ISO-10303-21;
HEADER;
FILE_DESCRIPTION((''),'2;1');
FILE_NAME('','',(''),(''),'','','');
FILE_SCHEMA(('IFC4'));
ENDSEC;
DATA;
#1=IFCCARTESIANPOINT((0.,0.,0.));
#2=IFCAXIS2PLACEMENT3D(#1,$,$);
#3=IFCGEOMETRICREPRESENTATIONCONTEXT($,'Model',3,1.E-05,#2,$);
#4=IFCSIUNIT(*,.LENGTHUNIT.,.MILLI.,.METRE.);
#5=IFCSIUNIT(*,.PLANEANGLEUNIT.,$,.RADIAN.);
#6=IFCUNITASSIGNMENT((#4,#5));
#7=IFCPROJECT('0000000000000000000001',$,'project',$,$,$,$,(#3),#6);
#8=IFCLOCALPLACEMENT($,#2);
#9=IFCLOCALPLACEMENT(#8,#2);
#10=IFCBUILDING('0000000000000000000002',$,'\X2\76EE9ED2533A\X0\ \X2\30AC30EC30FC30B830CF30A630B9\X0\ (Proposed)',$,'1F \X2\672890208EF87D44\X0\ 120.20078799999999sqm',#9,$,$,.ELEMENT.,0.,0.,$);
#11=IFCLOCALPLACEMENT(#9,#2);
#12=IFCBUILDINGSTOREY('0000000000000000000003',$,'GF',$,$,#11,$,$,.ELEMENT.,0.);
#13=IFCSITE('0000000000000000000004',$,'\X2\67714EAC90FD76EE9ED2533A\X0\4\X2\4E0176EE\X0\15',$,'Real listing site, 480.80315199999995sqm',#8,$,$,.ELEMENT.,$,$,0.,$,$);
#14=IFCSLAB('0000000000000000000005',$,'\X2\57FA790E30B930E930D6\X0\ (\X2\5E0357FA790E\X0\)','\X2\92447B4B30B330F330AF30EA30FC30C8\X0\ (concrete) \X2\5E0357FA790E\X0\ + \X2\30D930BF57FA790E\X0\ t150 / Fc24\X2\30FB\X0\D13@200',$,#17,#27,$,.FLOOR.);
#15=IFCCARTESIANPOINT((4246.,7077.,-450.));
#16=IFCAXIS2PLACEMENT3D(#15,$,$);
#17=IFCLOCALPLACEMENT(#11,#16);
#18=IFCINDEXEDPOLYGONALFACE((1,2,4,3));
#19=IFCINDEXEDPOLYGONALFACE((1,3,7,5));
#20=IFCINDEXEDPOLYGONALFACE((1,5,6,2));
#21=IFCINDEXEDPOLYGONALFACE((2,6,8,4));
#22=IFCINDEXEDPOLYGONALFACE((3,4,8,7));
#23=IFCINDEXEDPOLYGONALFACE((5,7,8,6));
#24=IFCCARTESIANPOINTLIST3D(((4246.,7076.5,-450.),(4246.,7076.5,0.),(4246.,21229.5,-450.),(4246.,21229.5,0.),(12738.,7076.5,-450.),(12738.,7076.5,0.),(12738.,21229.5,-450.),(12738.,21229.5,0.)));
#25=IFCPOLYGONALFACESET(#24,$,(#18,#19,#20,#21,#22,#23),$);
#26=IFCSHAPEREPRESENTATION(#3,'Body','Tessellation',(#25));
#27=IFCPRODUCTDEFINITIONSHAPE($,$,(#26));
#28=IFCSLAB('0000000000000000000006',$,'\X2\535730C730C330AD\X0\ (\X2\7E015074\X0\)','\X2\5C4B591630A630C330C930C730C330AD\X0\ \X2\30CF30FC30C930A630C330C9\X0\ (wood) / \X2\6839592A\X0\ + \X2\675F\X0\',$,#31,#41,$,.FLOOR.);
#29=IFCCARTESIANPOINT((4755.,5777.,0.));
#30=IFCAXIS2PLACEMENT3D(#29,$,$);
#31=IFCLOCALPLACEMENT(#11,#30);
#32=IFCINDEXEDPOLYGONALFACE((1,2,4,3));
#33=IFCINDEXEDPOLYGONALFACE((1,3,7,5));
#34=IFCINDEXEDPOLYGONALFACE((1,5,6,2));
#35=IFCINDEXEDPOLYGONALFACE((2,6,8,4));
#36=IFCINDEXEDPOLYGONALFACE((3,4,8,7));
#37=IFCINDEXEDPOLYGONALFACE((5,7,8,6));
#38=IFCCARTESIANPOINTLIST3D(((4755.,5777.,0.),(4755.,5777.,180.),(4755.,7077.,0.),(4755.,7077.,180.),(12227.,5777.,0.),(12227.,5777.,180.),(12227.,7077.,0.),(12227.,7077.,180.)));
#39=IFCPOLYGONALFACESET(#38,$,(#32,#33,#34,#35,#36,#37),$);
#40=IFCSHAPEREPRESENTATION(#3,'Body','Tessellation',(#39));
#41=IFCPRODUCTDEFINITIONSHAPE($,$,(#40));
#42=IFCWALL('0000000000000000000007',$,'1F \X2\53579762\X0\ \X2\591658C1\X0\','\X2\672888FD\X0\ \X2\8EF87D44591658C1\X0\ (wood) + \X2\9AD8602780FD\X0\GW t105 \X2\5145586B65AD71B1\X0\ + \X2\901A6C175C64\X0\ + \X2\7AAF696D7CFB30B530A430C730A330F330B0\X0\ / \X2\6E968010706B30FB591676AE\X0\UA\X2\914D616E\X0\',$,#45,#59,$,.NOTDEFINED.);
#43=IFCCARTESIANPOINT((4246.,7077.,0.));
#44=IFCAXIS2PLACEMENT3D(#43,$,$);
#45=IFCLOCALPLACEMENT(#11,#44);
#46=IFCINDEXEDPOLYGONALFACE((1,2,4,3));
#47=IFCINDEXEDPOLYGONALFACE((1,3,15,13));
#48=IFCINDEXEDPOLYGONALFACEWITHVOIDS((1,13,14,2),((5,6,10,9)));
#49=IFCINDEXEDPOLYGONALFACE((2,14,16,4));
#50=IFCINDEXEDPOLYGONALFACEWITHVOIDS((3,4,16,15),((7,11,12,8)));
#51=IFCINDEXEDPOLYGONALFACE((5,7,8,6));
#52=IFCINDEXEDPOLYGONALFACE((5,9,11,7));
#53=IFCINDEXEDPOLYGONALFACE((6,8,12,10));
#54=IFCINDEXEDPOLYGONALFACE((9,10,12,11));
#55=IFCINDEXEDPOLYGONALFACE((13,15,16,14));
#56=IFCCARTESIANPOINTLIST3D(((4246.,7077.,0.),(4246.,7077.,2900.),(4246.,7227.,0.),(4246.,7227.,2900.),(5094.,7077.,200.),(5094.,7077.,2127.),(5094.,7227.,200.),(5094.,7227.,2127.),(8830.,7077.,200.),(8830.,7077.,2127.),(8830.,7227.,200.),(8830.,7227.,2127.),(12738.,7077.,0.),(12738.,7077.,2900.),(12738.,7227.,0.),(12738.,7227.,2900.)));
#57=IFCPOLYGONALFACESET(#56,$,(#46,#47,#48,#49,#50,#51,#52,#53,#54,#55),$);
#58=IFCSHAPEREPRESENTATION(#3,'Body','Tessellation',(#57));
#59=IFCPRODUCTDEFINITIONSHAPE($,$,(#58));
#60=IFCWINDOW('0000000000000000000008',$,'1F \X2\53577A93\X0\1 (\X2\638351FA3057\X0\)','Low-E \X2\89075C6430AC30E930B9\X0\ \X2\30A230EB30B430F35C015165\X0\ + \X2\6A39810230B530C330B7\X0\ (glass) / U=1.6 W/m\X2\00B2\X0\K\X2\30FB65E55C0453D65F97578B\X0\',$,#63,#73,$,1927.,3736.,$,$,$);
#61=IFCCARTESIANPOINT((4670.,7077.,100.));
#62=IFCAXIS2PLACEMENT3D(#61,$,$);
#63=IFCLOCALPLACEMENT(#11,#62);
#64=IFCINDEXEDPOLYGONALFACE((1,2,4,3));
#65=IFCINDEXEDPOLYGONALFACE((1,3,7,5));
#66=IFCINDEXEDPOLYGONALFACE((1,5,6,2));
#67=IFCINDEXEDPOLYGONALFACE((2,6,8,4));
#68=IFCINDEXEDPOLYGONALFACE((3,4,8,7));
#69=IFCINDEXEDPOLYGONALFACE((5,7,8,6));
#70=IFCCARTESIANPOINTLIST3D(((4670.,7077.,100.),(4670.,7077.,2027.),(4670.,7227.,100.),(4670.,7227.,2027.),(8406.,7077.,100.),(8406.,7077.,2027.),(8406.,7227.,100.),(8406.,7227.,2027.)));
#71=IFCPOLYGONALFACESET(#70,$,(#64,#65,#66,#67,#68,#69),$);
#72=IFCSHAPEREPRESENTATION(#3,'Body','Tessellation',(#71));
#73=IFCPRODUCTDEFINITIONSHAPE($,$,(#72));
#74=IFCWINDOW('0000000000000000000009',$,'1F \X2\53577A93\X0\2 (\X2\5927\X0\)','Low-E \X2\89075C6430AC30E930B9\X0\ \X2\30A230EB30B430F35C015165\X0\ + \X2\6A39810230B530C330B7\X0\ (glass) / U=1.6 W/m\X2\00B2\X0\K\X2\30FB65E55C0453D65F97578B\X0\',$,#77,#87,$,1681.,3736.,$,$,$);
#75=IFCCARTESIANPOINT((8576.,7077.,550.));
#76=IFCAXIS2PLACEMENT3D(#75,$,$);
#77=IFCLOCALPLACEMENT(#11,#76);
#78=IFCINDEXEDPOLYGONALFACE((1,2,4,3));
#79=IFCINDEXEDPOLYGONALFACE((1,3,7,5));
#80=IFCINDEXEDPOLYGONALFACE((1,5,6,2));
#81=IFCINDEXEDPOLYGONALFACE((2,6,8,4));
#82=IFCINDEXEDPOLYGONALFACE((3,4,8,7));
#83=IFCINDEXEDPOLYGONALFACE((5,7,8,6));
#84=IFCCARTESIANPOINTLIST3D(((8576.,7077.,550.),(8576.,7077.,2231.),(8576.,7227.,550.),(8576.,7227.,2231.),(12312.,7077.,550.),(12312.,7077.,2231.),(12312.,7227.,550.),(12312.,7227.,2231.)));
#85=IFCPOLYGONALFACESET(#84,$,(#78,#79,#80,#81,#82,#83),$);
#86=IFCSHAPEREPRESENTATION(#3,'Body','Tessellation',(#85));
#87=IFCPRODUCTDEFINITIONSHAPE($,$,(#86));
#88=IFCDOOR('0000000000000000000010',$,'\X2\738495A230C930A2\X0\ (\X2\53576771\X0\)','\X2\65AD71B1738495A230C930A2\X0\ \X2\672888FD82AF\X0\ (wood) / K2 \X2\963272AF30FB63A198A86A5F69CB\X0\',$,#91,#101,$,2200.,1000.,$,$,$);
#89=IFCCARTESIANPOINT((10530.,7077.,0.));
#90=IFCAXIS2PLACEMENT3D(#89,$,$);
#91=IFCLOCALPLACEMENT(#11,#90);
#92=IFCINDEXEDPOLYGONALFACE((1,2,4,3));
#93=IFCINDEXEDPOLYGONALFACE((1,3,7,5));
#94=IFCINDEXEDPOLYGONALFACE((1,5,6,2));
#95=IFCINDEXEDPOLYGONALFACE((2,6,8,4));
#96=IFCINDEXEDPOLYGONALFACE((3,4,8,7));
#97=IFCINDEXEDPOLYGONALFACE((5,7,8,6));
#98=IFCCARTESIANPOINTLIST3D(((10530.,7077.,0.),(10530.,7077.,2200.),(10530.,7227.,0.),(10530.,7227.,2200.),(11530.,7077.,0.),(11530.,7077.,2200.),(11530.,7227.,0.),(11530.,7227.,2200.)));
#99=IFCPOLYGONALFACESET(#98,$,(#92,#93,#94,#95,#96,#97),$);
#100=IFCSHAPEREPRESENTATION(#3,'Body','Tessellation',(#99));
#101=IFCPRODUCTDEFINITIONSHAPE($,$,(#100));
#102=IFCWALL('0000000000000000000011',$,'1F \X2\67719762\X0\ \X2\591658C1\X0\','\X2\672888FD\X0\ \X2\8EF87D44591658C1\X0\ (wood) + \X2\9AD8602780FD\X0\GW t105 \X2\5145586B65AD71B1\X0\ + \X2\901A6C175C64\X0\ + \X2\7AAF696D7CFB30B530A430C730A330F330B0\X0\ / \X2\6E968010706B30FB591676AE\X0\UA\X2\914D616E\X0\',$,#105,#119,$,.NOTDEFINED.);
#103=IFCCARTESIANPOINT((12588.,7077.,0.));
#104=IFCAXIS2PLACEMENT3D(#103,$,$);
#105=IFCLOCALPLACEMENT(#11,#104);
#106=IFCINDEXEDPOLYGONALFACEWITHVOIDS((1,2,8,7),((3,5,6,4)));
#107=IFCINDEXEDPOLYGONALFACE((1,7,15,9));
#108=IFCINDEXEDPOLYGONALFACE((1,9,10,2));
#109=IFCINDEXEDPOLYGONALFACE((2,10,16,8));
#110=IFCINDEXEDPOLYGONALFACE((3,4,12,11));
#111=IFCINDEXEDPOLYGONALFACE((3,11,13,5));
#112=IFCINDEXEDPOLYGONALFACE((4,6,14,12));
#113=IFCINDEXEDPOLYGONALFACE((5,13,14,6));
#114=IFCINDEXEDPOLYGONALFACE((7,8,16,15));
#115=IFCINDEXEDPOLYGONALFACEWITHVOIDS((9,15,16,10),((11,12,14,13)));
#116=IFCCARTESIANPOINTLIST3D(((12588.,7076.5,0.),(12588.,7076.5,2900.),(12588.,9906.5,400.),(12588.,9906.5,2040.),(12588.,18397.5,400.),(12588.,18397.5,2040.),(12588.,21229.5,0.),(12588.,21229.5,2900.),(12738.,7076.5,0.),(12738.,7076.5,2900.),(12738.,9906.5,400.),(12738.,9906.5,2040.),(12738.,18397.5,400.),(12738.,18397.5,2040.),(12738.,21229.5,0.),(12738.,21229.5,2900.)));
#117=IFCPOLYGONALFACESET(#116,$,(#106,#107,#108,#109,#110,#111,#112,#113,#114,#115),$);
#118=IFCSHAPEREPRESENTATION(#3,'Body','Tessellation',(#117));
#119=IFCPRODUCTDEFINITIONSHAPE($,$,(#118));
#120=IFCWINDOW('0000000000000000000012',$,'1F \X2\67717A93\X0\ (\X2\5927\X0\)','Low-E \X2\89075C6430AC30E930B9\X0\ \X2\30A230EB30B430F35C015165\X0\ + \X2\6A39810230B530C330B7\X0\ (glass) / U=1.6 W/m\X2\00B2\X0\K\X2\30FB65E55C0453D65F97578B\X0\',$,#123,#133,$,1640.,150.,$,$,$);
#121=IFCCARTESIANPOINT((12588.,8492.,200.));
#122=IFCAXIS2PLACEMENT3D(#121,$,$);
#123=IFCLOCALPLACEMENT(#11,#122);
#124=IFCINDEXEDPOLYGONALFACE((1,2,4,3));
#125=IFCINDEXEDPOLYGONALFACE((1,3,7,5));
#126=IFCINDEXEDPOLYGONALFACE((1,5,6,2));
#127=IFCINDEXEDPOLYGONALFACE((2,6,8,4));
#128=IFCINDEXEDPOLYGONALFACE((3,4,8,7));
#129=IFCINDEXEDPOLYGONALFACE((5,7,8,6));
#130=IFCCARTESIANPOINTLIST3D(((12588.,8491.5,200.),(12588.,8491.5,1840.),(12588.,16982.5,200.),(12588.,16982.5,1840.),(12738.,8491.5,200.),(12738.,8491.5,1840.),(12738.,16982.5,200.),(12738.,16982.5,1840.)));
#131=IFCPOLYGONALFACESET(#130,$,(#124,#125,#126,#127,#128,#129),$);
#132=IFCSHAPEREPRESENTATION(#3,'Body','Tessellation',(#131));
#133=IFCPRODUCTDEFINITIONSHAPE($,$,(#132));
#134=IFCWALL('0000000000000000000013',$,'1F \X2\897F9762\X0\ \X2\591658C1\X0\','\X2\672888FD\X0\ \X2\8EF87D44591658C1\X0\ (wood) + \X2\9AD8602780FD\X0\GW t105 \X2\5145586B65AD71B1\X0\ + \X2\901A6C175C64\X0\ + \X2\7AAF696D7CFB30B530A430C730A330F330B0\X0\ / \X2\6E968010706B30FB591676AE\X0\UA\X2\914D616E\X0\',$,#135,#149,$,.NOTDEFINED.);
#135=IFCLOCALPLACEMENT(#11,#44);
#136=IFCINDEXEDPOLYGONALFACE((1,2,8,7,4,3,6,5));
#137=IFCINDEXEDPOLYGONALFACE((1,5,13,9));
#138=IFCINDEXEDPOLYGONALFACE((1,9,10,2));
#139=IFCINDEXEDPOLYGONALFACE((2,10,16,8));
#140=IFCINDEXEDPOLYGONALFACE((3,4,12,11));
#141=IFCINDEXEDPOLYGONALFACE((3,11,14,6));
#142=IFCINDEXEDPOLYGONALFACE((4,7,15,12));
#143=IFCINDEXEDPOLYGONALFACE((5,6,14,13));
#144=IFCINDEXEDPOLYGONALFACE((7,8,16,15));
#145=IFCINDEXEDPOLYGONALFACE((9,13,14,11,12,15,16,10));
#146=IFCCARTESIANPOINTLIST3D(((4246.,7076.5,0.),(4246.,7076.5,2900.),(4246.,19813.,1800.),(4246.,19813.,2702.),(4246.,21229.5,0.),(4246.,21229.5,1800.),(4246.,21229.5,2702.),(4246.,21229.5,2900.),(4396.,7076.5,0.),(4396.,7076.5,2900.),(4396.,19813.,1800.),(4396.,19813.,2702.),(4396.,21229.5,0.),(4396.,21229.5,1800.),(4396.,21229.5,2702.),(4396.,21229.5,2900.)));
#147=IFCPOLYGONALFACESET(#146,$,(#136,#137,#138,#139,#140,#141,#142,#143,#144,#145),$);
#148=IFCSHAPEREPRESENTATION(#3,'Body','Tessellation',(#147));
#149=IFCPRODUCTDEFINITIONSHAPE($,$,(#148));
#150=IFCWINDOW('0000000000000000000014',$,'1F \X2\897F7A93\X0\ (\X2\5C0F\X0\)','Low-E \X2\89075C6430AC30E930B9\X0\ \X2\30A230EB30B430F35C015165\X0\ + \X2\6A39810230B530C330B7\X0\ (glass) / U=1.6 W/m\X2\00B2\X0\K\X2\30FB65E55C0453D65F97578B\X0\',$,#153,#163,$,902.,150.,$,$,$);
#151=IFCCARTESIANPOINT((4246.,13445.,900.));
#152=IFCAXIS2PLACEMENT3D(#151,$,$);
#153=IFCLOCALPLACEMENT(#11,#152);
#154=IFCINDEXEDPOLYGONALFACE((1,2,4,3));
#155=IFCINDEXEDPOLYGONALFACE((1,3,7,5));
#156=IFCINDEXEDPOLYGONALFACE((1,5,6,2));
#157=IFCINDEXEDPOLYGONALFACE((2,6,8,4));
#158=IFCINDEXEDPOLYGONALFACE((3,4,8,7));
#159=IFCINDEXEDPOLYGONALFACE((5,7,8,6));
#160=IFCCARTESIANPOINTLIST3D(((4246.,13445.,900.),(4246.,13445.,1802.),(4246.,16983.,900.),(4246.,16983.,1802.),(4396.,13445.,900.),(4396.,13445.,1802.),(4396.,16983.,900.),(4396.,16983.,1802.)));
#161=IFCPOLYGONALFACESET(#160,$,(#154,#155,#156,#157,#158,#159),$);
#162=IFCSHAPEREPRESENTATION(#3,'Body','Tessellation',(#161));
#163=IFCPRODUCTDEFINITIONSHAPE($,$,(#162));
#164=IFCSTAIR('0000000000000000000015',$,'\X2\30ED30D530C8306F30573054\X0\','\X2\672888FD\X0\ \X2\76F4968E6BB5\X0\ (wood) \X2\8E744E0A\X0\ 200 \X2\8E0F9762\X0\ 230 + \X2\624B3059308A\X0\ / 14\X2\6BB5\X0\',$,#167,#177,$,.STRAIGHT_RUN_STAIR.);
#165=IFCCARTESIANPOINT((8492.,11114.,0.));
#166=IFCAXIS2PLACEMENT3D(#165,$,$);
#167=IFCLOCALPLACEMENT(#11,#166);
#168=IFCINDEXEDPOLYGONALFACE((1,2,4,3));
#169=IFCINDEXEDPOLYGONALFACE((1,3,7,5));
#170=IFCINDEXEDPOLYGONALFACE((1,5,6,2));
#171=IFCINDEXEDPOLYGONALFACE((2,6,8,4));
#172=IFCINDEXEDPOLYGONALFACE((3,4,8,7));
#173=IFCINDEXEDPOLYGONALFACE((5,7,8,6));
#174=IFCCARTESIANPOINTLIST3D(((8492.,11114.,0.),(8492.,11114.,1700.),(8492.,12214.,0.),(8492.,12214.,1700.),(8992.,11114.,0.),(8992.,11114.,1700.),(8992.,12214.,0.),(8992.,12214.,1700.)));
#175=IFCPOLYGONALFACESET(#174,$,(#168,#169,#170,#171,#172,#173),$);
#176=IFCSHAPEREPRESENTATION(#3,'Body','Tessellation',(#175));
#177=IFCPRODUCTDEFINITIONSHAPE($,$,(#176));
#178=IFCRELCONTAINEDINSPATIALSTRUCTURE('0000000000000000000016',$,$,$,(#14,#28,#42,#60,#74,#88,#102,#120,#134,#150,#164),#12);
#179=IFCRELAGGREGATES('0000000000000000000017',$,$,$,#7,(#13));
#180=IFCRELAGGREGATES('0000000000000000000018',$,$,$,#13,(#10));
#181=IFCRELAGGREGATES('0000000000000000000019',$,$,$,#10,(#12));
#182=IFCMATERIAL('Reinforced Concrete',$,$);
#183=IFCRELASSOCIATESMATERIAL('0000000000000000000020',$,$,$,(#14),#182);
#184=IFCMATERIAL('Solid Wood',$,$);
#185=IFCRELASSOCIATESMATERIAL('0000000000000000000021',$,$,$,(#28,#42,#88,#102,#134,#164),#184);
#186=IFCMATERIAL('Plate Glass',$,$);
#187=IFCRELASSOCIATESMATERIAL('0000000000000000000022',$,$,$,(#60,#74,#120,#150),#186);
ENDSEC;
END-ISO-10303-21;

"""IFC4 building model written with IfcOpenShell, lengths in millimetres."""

from ifc_helpers import new_model, si_unit, frame, frame_2d, origin, place, context, project, spatial, rectangle, extrude, material, element, fill, save


model = new_model("IFC4")

# Units and contexts
model_context = context("Model", 3, precision=1e-05, world=origin())
ifc_project = project(units=[si_unit("LENGTHUNIT", "METRE", prefix="MILLI"), si_unit("PLANEANGLEUNIT", "RADIAN")], contexts=[model_context])

# Site, building, storey
site_placement = place(None, origin())
site = spatial("IfcSite", under=ifc_project, at=site_placement, Name="東京都目黒区4丁目15", ObjectType="Real listing site, 480.80315199999995sqm", CompositionType="ELEMENT", RefElevation=0.0)
building_placement = place(site_placement, origin())
building = spatial("IfcBuilding", under=site, at=building_placement, Name="目黒区 ガレージハウス (Proposed)", ObjectType="1F 木造軸組 120.20078799999999sqm", CompositionType="ELEMENT", ElevationOfRefHeight=0.0, ElevationOfTerrain=0.0)
storey_placement = place(building_placement, origin())
storey = spatial("IfcBuildingStorey", under=building, at=storey_placement, Name="GF", CompositionType="ELEMENT", Elevation=0.0)

# Slabs
ifc_material_1 = material(Name="Reinforced Concrete")
slab_1_placement = place(storey_placement, frame((4246.0, 7077.0, -450.0)))
element("IfcSlab", 1, at=slab_1_placement, inside=storey, material=ifc_material_1, Name="基礎スラブ (布基礎)", Description="鉄筋コンクリート (concrete) 布基礎 + ベタ基礎 t150 / Fc24・D13@200", PredefinedType="FLOOR", context=model_context, shape_type="SweptSolid", body=[
    extrude(rectangle(XDim=8492.0, YDim=14153.0, at=frame_2d((4246.0, 7076.0))), frame((4246.0, 7077.0, -450.0)), (0.0, 0.0, 1.0), 450.0),
])
ifc_material_2 = material(Name="Solid Wood")
slab_2_placement = place(storey_placement, frame((4755.0, 5777.0, 0.0)))
element("IfcSlab", 2, at=slab_2_placement, inside=storey, material=ifc_material_2, Name="南デッキ (縁側)", Description="屋外ウッドデッキ ハードウッド (wood) / 根太 + 束", PredefinedType="FLOOR", context=model_context, shape_type="SweptSolid", body=[
    extrude(rectangle(XDim=7472.0, YDim=1300.0, at=frame_2d((3736.0, 650.0))), frame((4755.0, 5777.0, 0.0)), (0.0, 0.0, 1.0), 180.0),
])

# Wall, openings, windows, door
wall_1_placement = place(storey_placement, frame((4246.0, 7077.0, 0.0)))
wall_1 = element("IfcWall", 3, at=wall_1_placement, inside=storey, material=ifc_material_2, Name="1F 南面 外壁", Description="木製 軸組外壁 (wood) + 高性能GW t105 充填断熱 + 通気層 + 窯業系サイディング / 準耐火・外皮UA配慮", PredefinedType="NOTDEFINED", context=model_context, shape_type="SweptSolid", body=[
    extrude(rectangle(XDim=8492.0, YDim=150.0, at=frame_2d((4246.0, 75.0))), frame((4246.0, 7077.0, 0.0)), (0.0, 0.0, 1.0), 2900.0),
])
opening_1_placement = place(storey_placement, frame((4670.0, 7077.0, 100.0)))
opening_1 = element("IfcOpeningElement", 4, at=opening_1_placement, cuts=wall_1, PredefinedType="NOTDEFINED", context=model_context, shape_type="SweptSolid", body=[
    extrude(rectangle(XDim=3736.0, YDim=150.0, at=frame_2d((1868.0, 75.0))), frame((4670.0, 7077.0, 100.0)), (0.0, 0.0, 1.0), 1927.0),
])
opening_2_placement = place(storey_placement, frame((8576.0, 7077.0, 550.0)))
opening_2 = element("IfcOpeningElement", 5, at=opening_2_placement, cuts=wall_1, PredefinedType="NOTDEFINED", context=model_context, shape_type="SweptSolid", body=[
    extrude(rectangle(XDim=3736.0, YDim=150.0, at=frame_2d((1868.0, 75.0))), frame((8576.0, 7077.0, 550.0)), (0.0, 0.0, 1.0), 1681.0),
])
opening_3_placement = place(storey_placement, frame((10530.0, 7077.0, 0.0)))
opening_3 = element("IfcOpeningElement", 6, at=opening_3_placement, cuts=wall_1, PredefinedType="NOTDEFINED", context=model_context, shape_type="SweptSolid", body=[
    extrude(rectangle(XDim=1000.0, YDim=150.0, at=frame_2d((500.0, 75.0))), frame((10530.0, 7077.0, 0.0)), (0.0, 0.0, 1.0), 2200.0),
])
ifc_material_3 = material(Name="Plate Glass")
window_1_placement = place(storey_placement, frame((4670.0, 7077.0, 100.0)))
window_1 = element("IfcWindow", 7, at=window_1_placement, inside=storey, material=ifc_material_3, Name="1F 南窓1 (掃出し)", Description="Low-E 複層ガラス アルゴン封入 + 樹脂サッシ (glass) / U=1.6 W/m²K・日射取得型", OverallHeight=1927.0, OverallWidth=3736.0, context=model_context, shape_type="SweptSolid", body=[
    extrude(rectangle(XDim=3736.0, YDim=150.0, at=frame_2d((1868.0, 75.0))), frame((4670.0, 7077.0, 100.0)), (0.0, 0.0, 1.0), 1927.0),
])
fill(opening_1, window_1)
window_2_placement = place(storey_placement, frame((8576.0, 7077.0, 550.0)))
window_2 = element("IfcWindow", 8, at=window_2_placement, inside=storey, material=ifc_material_3, Name="1F 南窓2 (大)", Description="Low-E 複層ガラス アルゴン封入 + 樹脂サッシ (glass) / U=1.6 W/m²K・日射取得型", OverallHeight=1681.0, OverallWidth=3736.0, context=model_context, shape_type="SweptSolid", body=[
    extrude(rectangle(XDim=3736.0, YDim=150.0, at=frame_2d((1868.0, 75.0))), frame((8576.0, 7077.0, 550.0)), (0.0, 0.0, 1.0), 1681.0),
])
fill(opening_2, window_2)
door_placement = place(storey_placement, frame((10530.0, 7077.0, 0.0)))
door = element("IfcDoor", 9, at=door_placement, inside=storey, material=ifc_material_2, Name="玄関ドア (南東)", Description="断熱玄関ドア 木製芯 (wood) / K2 防犯・採風機構", OverallHeight=2200.0, OverallWidth=1000.0, context=model_context, shape_type="SweptSolid", body=[
    extrude(rectangle(XDim=1000.0, YDim=150.0, at=frame_2d((500.0, 75.0))), frame((10530.0, 7077.0, 0.0)), (0.0, 0.0, 1.0), 2200.0),
])
fill(opening_3, door)

# Walls, openings, windows
wall_2_placement = place(storey_placement, frame((12588.0, 7077.0, 0.0)))
wall_2 = element("IfcWall", 10, at=wall_2_placement, inside=storey, material=ifc_material_2, Name="1F 東面 外壁", Description="木製 軸組外壁 (wood) + 高性能GW t105 充填断熱 + 通気層 + 窯業系サイディング / 準耐火・外皮UA配慮", PredefinedType="NOTDEFINED", context=model_context, shape_type="SweptSolid", body=[
    extrude(rectangle(XDim=150.0, YDim=14153.0, at=frame_2d((75.0, 7076.0))), frame((12588.0, 7077.0, 0.0)), (0.0, 0.0, 1.0), 2900.0),
])
opening_4_placement = place(storey_placement, frame((12588.0, 8492.0, 200.0)))
opening_4 = element("IfcOpeningElement", 11, at=opening_4_placement, cuts=wall_2, PredefinedType="NOTDEFINED", context=model_context, shape_type="SweptSolid", body=[
    extrude(rectangle(XDim=150.0, YDim=8491.0, at=frame_2d((75.0, 4245.0))), frame((12588.0, 8492.0, 200.0)), (0.0, 0.0, 1.0), 1640.0),
])
window_3_placement = place(storey_placement, frame((12588.0, 8492.0, 200.0)))
window_3 = element("IfcWindow", 12, at=window_3_placement, inside=storey, material=ifc_material_3, Name="1F 東窓 (大)", Description="Low-E 複層ガラス アルゴン封入 + 樹脂サッシ (glass) / U=1.6 W/m²K・日射取得型", OverallHeight=1640.0, OverallWidth=150.0, context=model_context, shape_type="SweptSolid", body=[
    extrude(rectangle(XDim=150.0, YDim=8491.0, at=frame_2d((75.0, 4245.0))), frame((12588.0, 8492.0, 200.0)), (0.0, 0.0, 1.0), 1640.0),
])
fill(opening_4, window_3)
wall_3_placement = place(storey_placement, frame((4246.0, 7077.0, 0.0)))
wall_3 = element("IfcWall", 13, at=wall_3_placement, inside=storey, material=ifc_material_2, Name="1F 西面 外壁", Description="木製 軸組外壁 (wood) + 高性能GW t105 充填断熱 + 通気層 + 窯業系サイディング / 準耐火・外皮UA配慮", PredefinedType="NOTDEFINED", context=model_context, shape_type="SweptSolid", body=[
    extrude(rectangle(XDim=150.0, YDim=14153.0, at=frame_2d((75.0, 7076.0))), frame((4246.0, 7077.0, 0.0)), (0.0, 0.0, 1.0), 2900.0),
])
opening_5_placement = place(storey_placement, frame((4246.0, 13445.0, 900.0)))
opening_5 = element("IfcOpeningElement", 14, at=opening_5_placement, cuts=wall_3, PredefinedType="NOTDEFINED", context=model_context, shape_type="SweptSolid", body=[
    extrude(rectangle(XDim=150.0, YDim=3538.0, at=frame_2d((75.0, 1769.0))), frame((4246.0, 13445.0, 900.0)), (0.0, 0.0, 1.0), 902.0),
])
window_4_placement = place(storey_placement, frame((4246.0, 13445.0, 900.0)))
window_4 = element("IfcWindow", 15, at=window_4_placement, inside=storey, material=ifc_material_3, Name="1F 西窓 (小)", Description="Low-E 複層ガラス アルゴン封入 + 樹脂サッシ (glass) / U=1.6 W/m²K・日射取得型", OverallHeight=902.0, OverallWidth=150.0, context=model_context, shape_type="SweptSolid", body=[
    extrude(rectangle(XDim=150.0, YDim=3538.0, at=frame_2d((75.0, 1769.0))), frame((4246.0, 13445.0, 900.0)), (0.0, 0.0, 1.0), 902.0),
])
fill(opening_5, window_4)

# Stair
stair_placement = place(storey_placement, frame((8492.0, 11114.0, 0.0)))
element("IfcStair", 16, at=stair_placement, inside=storey, material=ifc_material_2, Name="ロフトはしご", Description="木製 直階段 (wood) 蹴上 200 踏面 230 + 手すり / 14段", PredefinedType="STRAIGHT_RUN_STAIR", context=model_context, shape_type="SweptSolid", body=[
    extrude(rectangle(XDim=500.0, YDim=1100.0, at=frame_2d((250.0, 550.0))), frame((8492.0, 11114.0, 0.0)), (0.0, 0.0, 1.0), 1700.0),
])

save(model, "model.ifc")
